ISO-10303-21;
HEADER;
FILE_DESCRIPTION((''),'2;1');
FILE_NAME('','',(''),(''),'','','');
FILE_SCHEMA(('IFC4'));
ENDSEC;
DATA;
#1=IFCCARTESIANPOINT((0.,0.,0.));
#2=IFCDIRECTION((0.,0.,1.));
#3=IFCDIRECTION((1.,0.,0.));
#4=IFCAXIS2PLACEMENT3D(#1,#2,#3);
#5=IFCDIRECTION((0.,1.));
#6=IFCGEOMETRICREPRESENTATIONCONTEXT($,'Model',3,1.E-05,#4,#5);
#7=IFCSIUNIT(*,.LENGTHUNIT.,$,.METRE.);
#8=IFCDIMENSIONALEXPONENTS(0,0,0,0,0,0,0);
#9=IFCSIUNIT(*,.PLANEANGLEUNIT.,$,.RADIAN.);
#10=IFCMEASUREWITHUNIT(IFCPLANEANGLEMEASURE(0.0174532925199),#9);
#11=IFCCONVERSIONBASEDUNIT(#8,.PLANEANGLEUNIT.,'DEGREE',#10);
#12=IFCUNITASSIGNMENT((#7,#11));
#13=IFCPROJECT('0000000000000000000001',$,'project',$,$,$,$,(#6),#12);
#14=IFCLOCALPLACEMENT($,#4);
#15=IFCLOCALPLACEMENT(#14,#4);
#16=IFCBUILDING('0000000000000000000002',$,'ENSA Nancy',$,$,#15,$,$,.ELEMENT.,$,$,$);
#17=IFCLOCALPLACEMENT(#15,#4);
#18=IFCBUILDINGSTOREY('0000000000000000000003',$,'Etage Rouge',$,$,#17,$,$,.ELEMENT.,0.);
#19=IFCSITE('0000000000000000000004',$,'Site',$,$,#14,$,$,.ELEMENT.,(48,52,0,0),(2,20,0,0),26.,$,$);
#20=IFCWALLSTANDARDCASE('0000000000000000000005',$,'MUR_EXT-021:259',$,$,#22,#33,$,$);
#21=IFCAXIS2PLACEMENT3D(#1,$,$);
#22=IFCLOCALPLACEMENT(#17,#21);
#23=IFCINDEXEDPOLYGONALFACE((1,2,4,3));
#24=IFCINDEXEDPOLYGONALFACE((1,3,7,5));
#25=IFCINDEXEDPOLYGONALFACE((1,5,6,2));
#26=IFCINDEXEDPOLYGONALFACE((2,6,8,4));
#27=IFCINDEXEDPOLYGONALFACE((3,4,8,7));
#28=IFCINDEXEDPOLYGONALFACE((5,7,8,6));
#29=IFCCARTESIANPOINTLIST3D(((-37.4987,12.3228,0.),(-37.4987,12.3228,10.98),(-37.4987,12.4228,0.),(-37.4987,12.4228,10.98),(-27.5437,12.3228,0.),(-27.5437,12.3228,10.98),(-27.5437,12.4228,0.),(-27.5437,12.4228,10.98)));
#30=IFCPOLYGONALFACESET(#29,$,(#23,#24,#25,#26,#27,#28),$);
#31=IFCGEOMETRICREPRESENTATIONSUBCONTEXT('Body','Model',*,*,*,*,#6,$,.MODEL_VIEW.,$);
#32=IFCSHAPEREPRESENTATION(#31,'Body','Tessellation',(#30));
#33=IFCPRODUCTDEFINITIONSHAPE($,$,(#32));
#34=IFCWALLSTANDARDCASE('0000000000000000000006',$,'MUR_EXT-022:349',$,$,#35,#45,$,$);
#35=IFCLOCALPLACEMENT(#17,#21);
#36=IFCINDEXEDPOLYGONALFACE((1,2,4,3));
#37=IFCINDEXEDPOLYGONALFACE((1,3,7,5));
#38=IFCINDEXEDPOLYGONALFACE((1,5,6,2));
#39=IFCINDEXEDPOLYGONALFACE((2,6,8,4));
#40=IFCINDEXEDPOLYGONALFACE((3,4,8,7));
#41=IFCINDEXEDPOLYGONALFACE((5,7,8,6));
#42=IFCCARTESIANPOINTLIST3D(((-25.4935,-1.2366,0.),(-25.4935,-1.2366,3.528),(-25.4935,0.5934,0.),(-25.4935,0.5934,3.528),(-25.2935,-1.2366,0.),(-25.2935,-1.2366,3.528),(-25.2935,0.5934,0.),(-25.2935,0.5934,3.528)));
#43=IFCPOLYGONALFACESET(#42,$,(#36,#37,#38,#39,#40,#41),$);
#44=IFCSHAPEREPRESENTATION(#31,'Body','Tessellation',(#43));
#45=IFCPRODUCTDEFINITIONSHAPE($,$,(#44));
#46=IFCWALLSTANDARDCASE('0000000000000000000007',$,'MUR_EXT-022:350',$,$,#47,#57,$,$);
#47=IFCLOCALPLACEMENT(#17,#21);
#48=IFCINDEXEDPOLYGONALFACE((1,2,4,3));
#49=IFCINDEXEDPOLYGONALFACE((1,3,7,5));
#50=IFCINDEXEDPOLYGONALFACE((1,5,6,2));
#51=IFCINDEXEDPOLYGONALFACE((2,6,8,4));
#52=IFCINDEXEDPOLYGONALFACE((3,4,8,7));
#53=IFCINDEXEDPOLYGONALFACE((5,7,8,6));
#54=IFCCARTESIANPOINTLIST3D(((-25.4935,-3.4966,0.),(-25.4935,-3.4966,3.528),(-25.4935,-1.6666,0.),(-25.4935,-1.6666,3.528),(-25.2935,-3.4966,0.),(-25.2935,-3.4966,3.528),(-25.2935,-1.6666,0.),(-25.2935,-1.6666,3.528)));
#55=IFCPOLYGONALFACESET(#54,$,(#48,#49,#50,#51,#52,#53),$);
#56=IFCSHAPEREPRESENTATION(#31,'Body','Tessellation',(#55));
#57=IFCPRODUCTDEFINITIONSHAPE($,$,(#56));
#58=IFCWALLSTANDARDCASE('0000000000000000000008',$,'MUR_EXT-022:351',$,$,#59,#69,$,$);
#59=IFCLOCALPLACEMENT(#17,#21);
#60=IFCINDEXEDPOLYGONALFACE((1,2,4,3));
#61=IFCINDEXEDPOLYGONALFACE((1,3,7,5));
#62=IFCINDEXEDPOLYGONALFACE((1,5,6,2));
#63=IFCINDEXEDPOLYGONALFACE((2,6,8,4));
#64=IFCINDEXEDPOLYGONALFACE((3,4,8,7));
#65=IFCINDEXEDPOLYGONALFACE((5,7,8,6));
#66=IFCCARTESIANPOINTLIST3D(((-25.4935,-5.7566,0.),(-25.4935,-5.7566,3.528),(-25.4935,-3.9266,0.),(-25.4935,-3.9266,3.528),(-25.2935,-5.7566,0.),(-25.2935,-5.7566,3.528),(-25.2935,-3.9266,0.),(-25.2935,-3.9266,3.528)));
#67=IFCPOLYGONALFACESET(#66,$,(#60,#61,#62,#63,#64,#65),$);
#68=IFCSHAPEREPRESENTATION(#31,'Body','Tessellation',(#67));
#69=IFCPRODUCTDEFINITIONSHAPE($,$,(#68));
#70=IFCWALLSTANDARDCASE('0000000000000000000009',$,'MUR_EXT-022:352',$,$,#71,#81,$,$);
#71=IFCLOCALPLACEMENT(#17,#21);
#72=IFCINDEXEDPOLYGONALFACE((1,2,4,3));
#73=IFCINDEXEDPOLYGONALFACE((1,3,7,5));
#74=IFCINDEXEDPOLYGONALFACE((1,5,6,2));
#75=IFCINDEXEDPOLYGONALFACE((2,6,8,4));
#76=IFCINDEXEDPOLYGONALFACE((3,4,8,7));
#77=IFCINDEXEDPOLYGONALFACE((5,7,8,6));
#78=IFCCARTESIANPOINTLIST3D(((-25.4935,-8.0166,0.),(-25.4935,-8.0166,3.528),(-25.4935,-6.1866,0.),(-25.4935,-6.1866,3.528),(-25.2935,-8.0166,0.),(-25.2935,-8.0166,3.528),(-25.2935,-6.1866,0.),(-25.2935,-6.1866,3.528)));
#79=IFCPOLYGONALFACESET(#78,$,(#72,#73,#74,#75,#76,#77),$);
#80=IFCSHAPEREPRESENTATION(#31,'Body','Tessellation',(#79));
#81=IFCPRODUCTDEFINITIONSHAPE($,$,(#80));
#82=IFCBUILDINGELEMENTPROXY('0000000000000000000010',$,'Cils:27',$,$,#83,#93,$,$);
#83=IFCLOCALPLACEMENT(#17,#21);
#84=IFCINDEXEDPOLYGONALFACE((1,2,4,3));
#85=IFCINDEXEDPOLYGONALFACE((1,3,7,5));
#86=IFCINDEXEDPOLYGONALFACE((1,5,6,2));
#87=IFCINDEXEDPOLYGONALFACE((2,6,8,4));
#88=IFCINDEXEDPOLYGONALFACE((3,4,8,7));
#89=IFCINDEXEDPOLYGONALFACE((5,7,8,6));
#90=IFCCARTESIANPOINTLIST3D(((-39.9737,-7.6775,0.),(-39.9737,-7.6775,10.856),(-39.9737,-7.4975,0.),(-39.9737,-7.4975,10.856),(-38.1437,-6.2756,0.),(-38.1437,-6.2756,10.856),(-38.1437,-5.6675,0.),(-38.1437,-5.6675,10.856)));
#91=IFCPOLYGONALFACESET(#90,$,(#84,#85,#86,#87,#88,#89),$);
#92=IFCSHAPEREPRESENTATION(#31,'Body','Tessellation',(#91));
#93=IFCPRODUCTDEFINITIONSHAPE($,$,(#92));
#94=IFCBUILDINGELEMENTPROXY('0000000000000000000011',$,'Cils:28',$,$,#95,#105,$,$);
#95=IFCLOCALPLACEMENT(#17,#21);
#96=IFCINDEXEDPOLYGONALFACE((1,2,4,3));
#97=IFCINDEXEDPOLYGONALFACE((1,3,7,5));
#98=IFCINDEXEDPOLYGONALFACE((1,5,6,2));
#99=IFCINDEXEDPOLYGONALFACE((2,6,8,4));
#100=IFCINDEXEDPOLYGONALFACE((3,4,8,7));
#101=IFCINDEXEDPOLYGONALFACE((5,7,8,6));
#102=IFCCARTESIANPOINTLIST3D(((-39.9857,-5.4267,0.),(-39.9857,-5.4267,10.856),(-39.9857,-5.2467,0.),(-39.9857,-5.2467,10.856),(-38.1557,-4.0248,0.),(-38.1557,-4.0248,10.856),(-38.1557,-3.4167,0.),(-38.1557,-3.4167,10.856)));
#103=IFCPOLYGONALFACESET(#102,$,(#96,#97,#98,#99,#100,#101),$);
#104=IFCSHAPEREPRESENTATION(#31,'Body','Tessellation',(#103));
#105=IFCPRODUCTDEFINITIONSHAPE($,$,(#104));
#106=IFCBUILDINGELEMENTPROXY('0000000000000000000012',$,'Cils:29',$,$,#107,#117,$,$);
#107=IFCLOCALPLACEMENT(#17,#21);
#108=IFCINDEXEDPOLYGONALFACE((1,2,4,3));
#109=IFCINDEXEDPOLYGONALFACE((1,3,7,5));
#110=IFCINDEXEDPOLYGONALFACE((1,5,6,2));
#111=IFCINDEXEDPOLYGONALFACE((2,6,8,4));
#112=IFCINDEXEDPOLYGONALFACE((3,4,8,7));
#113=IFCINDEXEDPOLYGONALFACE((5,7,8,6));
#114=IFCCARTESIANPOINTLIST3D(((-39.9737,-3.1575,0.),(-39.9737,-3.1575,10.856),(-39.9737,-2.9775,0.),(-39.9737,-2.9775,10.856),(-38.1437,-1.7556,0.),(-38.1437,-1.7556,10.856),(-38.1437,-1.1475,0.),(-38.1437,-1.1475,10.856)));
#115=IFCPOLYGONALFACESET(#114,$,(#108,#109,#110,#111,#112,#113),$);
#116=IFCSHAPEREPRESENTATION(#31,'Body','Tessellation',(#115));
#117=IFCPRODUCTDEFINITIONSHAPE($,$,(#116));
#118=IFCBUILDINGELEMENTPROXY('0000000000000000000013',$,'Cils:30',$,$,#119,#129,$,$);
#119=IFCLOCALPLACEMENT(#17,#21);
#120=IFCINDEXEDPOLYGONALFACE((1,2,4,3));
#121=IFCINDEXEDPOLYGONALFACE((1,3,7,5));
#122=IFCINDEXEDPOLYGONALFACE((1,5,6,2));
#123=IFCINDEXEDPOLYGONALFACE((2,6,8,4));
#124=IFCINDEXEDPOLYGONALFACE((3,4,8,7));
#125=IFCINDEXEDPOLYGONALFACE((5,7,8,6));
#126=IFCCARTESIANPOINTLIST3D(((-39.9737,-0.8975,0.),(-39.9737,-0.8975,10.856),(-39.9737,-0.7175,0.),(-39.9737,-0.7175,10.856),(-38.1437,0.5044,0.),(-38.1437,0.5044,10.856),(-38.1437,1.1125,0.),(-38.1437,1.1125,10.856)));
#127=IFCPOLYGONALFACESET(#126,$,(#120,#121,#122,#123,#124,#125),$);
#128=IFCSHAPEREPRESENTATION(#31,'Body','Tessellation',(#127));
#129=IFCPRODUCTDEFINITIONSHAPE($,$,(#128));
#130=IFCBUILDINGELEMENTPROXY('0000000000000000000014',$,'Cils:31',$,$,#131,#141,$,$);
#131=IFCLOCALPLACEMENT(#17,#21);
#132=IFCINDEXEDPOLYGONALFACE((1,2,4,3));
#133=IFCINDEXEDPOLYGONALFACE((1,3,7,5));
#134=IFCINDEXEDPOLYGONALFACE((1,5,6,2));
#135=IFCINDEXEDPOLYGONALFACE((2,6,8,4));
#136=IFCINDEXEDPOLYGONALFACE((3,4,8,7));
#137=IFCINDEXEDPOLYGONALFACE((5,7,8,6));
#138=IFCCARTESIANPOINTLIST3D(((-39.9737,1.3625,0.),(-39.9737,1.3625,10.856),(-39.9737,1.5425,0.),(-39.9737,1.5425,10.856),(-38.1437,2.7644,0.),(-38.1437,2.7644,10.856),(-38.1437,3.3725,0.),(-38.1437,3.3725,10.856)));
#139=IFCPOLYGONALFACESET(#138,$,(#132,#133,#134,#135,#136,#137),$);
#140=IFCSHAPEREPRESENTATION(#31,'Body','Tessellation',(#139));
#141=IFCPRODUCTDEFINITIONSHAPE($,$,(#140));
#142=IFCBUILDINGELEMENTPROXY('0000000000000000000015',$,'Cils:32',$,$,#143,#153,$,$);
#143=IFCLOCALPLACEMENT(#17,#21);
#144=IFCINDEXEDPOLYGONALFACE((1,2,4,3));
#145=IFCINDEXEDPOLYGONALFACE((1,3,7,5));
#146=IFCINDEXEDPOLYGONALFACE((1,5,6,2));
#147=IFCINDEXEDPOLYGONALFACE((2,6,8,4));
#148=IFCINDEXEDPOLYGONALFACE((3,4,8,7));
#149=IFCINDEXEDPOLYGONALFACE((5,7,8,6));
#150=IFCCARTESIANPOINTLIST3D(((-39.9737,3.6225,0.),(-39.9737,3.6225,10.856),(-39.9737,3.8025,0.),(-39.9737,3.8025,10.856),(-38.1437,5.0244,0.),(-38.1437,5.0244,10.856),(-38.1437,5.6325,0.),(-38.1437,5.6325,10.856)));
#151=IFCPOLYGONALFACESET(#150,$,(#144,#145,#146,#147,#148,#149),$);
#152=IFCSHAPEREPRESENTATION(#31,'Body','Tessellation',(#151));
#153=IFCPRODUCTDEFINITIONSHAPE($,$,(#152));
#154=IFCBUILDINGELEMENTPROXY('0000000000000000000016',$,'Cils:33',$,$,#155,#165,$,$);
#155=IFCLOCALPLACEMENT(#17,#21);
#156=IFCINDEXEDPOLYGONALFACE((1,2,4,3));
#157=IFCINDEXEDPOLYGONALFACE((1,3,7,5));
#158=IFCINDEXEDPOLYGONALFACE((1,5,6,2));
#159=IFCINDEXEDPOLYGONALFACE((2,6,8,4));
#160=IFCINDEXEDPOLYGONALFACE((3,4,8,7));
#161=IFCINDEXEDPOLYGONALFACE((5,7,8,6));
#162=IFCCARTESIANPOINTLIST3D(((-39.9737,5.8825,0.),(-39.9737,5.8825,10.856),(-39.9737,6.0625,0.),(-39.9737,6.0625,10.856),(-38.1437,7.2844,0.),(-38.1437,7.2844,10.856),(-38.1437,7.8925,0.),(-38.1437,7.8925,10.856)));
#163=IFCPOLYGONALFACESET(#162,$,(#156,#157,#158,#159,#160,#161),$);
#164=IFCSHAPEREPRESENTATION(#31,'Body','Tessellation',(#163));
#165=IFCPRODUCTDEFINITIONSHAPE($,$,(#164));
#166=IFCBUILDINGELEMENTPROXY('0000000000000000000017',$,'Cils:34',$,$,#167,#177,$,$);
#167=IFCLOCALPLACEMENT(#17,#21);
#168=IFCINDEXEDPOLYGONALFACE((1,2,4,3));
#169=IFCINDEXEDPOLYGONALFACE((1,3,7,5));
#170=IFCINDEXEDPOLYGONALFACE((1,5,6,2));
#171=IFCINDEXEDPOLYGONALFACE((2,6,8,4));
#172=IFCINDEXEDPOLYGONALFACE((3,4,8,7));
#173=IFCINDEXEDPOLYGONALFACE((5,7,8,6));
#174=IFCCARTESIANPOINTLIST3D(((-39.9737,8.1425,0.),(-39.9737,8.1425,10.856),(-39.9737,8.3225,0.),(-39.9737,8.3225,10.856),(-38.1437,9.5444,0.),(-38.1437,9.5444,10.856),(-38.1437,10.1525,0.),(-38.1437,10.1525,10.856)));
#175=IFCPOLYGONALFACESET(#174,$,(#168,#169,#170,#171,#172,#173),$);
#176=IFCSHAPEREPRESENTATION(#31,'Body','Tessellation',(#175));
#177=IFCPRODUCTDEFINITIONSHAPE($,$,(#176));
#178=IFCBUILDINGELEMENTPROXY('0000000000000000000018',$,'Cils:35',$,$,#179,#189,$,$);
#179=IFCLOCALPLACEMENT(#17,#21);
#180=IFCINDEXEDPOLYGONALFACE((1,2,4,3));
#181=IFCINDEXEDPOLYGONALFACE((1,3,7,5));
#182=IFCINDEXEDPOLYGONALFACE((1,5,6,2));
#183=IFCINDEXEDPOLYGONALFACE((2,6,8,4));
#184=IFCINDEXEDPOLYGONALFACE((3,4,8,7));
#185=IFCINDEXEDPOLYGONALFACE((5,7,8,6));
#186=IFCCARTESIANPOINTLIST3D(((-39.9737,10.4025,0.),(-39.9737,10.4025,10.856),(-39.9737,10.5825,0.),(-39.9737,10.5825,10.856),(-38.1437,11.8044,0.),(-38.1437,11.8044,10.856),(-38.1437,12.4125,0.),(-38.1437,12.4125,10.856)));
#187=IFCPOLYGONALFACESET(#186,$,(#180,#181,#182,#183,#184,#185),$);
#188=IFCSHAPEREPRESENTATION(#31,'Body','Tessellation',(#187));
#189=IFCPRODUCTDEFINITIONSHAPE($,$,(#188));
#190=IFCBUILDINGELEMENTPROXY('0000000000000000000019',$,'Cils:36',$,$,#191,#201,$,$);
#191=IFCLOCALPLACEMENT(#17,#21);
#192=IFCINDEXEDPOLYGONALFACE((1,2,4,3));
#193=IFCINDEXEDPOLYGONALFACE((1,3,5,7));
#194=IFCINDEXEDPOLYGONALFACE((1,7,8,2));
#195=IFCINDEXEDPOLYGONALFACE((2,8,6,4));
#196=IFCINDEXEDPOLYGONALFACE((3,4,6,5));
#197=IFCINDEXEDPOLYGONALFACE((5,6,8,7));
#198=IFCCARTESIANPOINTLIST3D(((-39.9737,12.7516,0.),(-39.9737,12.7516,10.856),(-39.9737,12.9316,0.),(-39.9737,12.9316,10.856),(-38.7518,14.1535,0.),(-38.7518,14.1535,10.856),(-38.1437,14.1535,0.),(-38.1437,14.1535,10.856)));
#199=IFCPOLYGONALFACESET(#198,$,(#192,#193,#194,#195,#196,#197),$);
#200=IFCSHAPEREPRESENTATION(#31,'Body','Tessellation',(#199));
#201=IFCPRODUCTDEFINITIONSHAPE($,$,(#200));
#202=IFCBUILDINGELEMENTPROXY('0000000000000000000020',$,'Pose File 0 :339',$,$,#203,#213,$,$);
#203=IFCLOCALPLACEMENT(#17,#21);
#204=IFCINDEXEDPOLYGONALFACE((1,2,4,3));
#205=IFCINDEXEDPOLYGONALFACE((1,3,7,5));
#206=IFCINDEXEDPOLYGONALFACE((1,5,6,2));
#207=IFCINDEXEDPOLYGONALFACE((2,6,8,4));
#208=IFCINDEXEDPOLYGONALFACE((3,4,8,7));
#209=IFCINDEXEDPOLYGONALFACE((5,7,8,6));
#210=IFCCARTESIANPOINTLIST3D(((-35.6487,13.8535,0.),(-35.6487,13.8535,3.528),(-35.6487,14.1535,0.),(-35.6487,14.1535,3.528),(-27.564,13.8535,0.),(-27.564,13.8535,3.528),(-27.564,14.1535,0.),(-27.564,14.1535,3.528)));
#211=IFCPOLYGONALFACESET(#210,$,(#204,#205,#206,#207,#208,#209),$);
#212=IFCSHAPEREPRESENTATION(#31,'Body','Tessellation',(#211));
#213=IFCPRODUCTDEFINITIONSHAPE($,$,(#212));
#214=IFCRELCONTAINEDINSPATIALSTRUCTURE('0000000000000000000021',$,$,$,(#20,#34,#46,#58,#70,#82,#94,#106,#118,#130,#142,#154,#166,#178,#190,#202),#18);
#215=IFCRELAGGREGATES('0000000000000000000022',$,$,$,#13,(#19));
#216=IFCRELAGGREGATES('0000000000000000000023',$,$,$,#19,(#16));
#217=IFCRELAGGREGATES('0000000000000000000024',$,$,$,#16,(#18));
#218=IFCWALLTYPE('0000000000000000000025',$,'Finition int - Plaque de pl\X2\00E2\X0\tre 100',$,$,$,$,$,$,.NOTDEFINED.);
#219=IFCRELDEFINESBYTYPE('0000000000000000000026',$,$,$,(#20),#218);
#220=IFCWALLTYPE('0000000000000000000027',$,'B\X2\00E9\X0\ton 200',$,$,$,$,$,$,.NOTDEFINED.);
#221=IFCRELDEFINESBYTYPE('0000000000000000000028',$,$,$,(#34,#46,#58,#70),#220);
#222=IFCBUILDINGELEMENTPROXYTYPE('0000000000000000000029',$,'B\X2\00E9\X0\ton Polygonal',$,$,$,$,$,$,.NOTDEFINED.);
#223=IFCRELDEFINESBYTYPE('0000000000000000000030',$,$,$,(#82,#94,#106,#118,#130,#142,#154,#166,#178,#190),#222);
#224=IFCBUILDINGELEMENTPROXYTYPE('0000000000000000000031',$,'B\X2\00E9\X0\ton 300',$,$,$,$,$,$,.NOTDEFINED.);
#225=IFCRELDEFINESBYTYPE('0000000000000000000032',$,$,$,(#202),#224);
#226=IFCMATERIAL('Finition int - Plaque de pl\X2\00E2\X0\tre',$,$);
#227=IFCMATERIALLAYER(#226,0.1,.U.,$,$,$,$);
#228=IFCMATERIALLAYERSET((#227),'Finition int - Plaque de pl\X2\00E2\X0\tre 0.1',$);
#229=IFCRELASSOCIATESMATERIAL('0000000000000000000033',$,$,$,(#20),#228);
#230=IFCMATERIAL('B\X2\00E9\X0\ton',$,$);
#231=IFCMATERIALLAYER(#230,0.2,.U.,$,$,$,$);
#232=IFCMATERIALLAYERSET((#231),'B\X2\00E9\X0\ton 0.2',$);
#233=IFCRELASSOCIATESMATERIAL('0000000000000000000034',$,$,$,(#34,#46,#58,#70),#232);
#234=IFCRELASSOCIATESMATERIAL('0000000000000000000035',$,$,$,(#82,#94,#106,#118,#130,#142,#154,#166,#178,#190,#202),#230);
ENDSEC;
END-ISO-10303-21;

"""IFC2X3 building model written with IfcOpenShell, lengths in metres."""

from ifc_helpers import new_model, entity, si_unit, converted_unit, direction, frame, origin_with_axes, place, context, subcontext, project, spatial, polyline, outline, extrude, material, layer, layer_set, layer_usage, type_object, element, save


model = new_model("IFC2X3")

# Units and contexts
model_context = context("Model", 3, precision=1e-05, world=origin_with_axes(), true_north=direction((0.0, 1.0)))
body_context = subcontext(model_context, "Body", "Model", "MODEL_VIEW")
ifc_project = project(units=[si_unit("LENGTHUNIT", "METRE"), converted_unit("PLANEANGLEUNIT", "DEGREE", entity("IfcPlaneAngleMeasure", 0.0174532925199), si_unit("PLANEANGLEUNIT", "RADIAN"), dimensions=[0, 0, 0, 0, 0, 0, 0])], contexts=[model_context])

# Site, building, storey
site_placement = place(None, origin_with_axes())
site = spatial("IfcSite", under=ifc_project, at=site_placement, Name="Site", CompositionType="ELEMENT", RefLatitude=(48, 52, 0, 0), RefLongitude=(2, 20, 0, 0), RefElevation=26.0)
building_placement = place(site_placement, origin_with_axes())
building = spatial("IfcBuilding", under=site, at=building_placement, Name="ENSA Nancy", CompositionType="ELEMENT")
storey_placement = place(building_placement, origin_with_axes())
storey = spatial("IfcBuildingStorey", under=building, at=storey_placement, Name="Etage Rouge", CompositionType="ELEMENT", Elevation=0.0)

# Walls
ifc_material_1 = material(Name="Finition int - Plaque de plâtre")
ifc_layer_1 = layer(ifc_material_1, 0.1, ventilated="UNKNOWN")
ifc_layer_set_1 = layer_set([ifc_layer_1], Name="Finition int - Plaque de plâtre 0.1")
ifc_layer_usage_1 = layer_usage(ifc_layer_set_1, "AXIS2", "POSITIVE", -0.1)
wall_type_1 = type_object("IfcWallType", Name="Finition int - Plaque de plâtre 100", PredefinedType="NOTDEFINED")
wall_1_placement = place(storey_placement, frame((-37.4987, 12.4228, 0.0), z_axis=(0.0, 0.0, 1.0), x_axis=(1.0, 0.0, 0.0)))
element("IfcWallStandardCase", 1, at=wall_1_placement, inside=storey, type_object=wall_type_1, material=ifc_layer_usage_1, Name="MUR_EXT-021:259", context=body_context, shape_type="SweptSolid", body=[
    extrude(outline(polyline([(0.0, -0.1), (9.955, -0.1), (9.955, 0.0), (0.0, 0.0), (0.0, -0.1)])), origin_with_axes(), (0.0, 0.0, 1.0), 10.98),
])
ifc_material_2 = material(Name="Béton")
ifc_layer_2 = layer(ifc_material_2, 0.2, ventilated="UNKNOWN")
ifc_layer_set_2 = layer_set([ifc_layer_2], Name="Béton 0.2")
ifc_layer_usage_2 = layer_usage(ifc_layer_set_2, "AXIS2", "POSITIVE", -0.2)
wall_type_2 = type_object("IfcWallType", Name="Béton 200", PredefinedType="NOTDEFINED")
wall_2_placement = place(storey_placement, frame((-25.2935, 0.5934, 0.0), z_axis=(0.0, 0.0, 1.0), x_axis=(0.0, -1.0, 0.0)))
element("IfcWallStandardCase", 2, at=wall_2_placement, inside=storey, type_object=wall_type_2, material=ifc_layer_usage_2, Name="MUR_EXT-022:349", context=body_context, shape_type="SweptSolid", body=[
    extrude(outline(polyline([(0.0, -0.2), (1.83, -0.2), (1.83, 0.0), (0.0, 0.0), (0.0, -0.2)])), origin_with_axes(), (0.0, 0.0, 1.0), 3.528),
])
ifc_layer_usage_3 = layer_usage(ifc_layer_set_2, "AXIS2", "POSITIVE", -0.2)
wall_3_placement = place(storey_placement, frame((-25.2935, -1.6666, 0.0), z_axis=(0.0, 0.0, 1.0), x_axis=(0.0, -1.0, 0.0)))
element("IfcWallStandardCase", 3, at=wall_3_placement, inside=storey, type_object=wall_type_2, material=ifc_layer_usage_3, Name="MUR_EXT-022:350", context=body_context, shape_type="SweptSolid", body=[
    extrude(outline(polyline([(0.0, -0.2), (1.83, -0.2), (1.83, 0.0), (0.0, 0.0), (0.0, -0.2)])), origin_with_axes(), (0.0, 0.0, 1.0), 3.528),
])
ifc_layer_usage_4 = layer_usage(ifc_layer_set_2, "AXIS2", "POSITIVE", -0.2)
wall_4_placement = place(storey_placement, frame((-25.2935, -3.9266, 0.0), z_axis=(0.0, 0.0, 1.0), x_axis=(0.0, -1.0, 0.0)))
element("IfcWallStandardCase", 4, at=wall_4_placement, inside=storey, type_object=wall_type_2, material=ifc_layer_usage_4, Name="MUR_EXT-022:351", context=body_context, shape_type="SweptSolid", body=[
    extrude(outline(polyline([(0.0, -0.2), (1.83, -0.2), (1.83, 0.0), (0.0, 0.0), (0.0, -0.2)])), origin_with_axes(), (0.0, 0.0, 1.0), 3.528),
])
ifc_layer_usage_5 = layer_usage(ifc_layer_set_2, "AXIS2", "POSITIVE", -0.2)
wall_5_placement = place(storey_placement, frame((-25.2935, -6.1866, 0.0), z_axis=(0.0, 0.0, 1.0), x_axis=(0.0, -1.0, 0.0)))
element("IfcWallStandardCase", 5, at=wall_5_placement, inside=storey, type_object=wall_type_2, material=ifc_layer_usage_5, Name="MUR_EXT-022:352", context=body_context, shape_type="SweptSolid", body=[
    extrude(outline(polyline([(0.0, -0.2), (1.83, -0.2), (1.83, 0.0), (0.0, 0.0), (0.0, -0.2)])), origin_with_axes(), (0.0, 0.0, 1.0), 3.528),
])

# Building element proxies
building_element_proxy_type_1 = type_object("IfcBuildingElementProxyType", Name="Béton Polygonal", PredefinedType="NOTDEFINED")
for number, where, z_axis, x_axis, name in (
    (6, (-38.1437, -5.6675, 0.0), (0.0, 0.0, 1.0), (-0.707107, -0.707107, 0.0), "Cils:27"),
    (7, (-38.1557, -3.4167, 0.0), (0.0, 0.0, 1.0), (-0.707107, -0.707107, 0.0), "Cils:28"),
    (8, (-38.1437, -1.1475, 0.0), (0.0, 0.0, 1.0), (-0.707107, -0.707107, 0.0), "Cils:29"),
    (9, (-38.1437, 1.1125, 0.0), (0.0, 0.0, 1.0), (-0.707107, -0.707107, 0.0), "Cils:30"),
    (10, (-38.1437, 3.3725, 0.0), (0.0, 0.0, 1.0), (-0.707107, -0.707107, 0.0), "Cils:31"),
    (11, (-38.1437, 5.6325, 0.0), (0.0, 0.0, 1.0), (-0.707107, -0.707107, 0.0), "Cils:32"),
    (12, (-38.1437, 7.8925, 0.0), (0.0, 0.0, 1.0), (-0.707107, -0.707107, 0.0), "Cils:33"),
    (13, (-38.1437, 10.1525, 0.0), (0.0, 0.0, 1.0), (-0.707107, -0.707107, 0.0), "Cils:34"),
    (14, (-38.1437, 12.4125, 0.0), (0.0, 0.0, 1.0), (-0.707107, -0.707107, 0.0), "Cils:35"),
):
    element("IfcBuildingElementProxy", number, at=place(storey_placement, frame(where, z_axis=z_axis, x_axis=x_axis)), inside=storey, type_object=building_element_proxy_type_1, material=ifc_material_2, Name=name, context=body_context, shape_type="SweptSolid", body=[
        extrude(outline(polyline([(0.0, 0.0), (2.588, 0.0), (2.7153, 0.1273), (0.43, 0.43), (0.0, 0.0)])), origin_with_axes(), (0.0, 0.0, 1.0), 10.856),
    ])
proxy_1_placement = place(storey_placement, frame((-39.9737, 12.9316, 0.0), z_axis=(0.0, 0.0, 1.0), x_axis=(0.0, -1.0, 0.0)))
element("IfcBuildingElementProxy", 15, at=proxy_1_placement, inside=storey, type_object=building_element_proxy_type_1, material=ifc_material_2, Name="Cils:36", context=body_context, shape_type="SweptSolid", body=[
    extrude(outline(polyline([(0.0, 0.0), (0.18, 0.0), (-1.2219, 1.83), (-1.2219, 1.2219), (0.0, 0.0)])), origin_with_axes(), (0.0, 0.0, 1.0), 10.856),
])
building_element_proxy_type_2 = type_object("IfcBuildingElementProxyType", Name="Béton 300", PredefinedType="NOTDEFINED")
proxy_2_placement = place(storey_placement, frame((-27.564, 13.8535, 0.0), z_axis=(0.0, 0.0, 1.0), x_axis=(-1.0, 0.0, 0.0)))
element("IfcBuildingElementProxy", 16, at=proxy_2_placement, inside=storey, type_object=building_element_proxy_type_2, material=ifc_material_2, Name="Pose File 0 :339", context=body_context, shape_type="SweptSolid", body=[
    extrude(outline(polyline([(0.0, -0.3), (8.0848, -0.3), (8.0848, 0.0), (0.0, 0.0), (0.0, -0.3)])), origin_with_axes(), (0.0, 0.0, 1.0), 3.528),
])

save(model, "model.ifc")
